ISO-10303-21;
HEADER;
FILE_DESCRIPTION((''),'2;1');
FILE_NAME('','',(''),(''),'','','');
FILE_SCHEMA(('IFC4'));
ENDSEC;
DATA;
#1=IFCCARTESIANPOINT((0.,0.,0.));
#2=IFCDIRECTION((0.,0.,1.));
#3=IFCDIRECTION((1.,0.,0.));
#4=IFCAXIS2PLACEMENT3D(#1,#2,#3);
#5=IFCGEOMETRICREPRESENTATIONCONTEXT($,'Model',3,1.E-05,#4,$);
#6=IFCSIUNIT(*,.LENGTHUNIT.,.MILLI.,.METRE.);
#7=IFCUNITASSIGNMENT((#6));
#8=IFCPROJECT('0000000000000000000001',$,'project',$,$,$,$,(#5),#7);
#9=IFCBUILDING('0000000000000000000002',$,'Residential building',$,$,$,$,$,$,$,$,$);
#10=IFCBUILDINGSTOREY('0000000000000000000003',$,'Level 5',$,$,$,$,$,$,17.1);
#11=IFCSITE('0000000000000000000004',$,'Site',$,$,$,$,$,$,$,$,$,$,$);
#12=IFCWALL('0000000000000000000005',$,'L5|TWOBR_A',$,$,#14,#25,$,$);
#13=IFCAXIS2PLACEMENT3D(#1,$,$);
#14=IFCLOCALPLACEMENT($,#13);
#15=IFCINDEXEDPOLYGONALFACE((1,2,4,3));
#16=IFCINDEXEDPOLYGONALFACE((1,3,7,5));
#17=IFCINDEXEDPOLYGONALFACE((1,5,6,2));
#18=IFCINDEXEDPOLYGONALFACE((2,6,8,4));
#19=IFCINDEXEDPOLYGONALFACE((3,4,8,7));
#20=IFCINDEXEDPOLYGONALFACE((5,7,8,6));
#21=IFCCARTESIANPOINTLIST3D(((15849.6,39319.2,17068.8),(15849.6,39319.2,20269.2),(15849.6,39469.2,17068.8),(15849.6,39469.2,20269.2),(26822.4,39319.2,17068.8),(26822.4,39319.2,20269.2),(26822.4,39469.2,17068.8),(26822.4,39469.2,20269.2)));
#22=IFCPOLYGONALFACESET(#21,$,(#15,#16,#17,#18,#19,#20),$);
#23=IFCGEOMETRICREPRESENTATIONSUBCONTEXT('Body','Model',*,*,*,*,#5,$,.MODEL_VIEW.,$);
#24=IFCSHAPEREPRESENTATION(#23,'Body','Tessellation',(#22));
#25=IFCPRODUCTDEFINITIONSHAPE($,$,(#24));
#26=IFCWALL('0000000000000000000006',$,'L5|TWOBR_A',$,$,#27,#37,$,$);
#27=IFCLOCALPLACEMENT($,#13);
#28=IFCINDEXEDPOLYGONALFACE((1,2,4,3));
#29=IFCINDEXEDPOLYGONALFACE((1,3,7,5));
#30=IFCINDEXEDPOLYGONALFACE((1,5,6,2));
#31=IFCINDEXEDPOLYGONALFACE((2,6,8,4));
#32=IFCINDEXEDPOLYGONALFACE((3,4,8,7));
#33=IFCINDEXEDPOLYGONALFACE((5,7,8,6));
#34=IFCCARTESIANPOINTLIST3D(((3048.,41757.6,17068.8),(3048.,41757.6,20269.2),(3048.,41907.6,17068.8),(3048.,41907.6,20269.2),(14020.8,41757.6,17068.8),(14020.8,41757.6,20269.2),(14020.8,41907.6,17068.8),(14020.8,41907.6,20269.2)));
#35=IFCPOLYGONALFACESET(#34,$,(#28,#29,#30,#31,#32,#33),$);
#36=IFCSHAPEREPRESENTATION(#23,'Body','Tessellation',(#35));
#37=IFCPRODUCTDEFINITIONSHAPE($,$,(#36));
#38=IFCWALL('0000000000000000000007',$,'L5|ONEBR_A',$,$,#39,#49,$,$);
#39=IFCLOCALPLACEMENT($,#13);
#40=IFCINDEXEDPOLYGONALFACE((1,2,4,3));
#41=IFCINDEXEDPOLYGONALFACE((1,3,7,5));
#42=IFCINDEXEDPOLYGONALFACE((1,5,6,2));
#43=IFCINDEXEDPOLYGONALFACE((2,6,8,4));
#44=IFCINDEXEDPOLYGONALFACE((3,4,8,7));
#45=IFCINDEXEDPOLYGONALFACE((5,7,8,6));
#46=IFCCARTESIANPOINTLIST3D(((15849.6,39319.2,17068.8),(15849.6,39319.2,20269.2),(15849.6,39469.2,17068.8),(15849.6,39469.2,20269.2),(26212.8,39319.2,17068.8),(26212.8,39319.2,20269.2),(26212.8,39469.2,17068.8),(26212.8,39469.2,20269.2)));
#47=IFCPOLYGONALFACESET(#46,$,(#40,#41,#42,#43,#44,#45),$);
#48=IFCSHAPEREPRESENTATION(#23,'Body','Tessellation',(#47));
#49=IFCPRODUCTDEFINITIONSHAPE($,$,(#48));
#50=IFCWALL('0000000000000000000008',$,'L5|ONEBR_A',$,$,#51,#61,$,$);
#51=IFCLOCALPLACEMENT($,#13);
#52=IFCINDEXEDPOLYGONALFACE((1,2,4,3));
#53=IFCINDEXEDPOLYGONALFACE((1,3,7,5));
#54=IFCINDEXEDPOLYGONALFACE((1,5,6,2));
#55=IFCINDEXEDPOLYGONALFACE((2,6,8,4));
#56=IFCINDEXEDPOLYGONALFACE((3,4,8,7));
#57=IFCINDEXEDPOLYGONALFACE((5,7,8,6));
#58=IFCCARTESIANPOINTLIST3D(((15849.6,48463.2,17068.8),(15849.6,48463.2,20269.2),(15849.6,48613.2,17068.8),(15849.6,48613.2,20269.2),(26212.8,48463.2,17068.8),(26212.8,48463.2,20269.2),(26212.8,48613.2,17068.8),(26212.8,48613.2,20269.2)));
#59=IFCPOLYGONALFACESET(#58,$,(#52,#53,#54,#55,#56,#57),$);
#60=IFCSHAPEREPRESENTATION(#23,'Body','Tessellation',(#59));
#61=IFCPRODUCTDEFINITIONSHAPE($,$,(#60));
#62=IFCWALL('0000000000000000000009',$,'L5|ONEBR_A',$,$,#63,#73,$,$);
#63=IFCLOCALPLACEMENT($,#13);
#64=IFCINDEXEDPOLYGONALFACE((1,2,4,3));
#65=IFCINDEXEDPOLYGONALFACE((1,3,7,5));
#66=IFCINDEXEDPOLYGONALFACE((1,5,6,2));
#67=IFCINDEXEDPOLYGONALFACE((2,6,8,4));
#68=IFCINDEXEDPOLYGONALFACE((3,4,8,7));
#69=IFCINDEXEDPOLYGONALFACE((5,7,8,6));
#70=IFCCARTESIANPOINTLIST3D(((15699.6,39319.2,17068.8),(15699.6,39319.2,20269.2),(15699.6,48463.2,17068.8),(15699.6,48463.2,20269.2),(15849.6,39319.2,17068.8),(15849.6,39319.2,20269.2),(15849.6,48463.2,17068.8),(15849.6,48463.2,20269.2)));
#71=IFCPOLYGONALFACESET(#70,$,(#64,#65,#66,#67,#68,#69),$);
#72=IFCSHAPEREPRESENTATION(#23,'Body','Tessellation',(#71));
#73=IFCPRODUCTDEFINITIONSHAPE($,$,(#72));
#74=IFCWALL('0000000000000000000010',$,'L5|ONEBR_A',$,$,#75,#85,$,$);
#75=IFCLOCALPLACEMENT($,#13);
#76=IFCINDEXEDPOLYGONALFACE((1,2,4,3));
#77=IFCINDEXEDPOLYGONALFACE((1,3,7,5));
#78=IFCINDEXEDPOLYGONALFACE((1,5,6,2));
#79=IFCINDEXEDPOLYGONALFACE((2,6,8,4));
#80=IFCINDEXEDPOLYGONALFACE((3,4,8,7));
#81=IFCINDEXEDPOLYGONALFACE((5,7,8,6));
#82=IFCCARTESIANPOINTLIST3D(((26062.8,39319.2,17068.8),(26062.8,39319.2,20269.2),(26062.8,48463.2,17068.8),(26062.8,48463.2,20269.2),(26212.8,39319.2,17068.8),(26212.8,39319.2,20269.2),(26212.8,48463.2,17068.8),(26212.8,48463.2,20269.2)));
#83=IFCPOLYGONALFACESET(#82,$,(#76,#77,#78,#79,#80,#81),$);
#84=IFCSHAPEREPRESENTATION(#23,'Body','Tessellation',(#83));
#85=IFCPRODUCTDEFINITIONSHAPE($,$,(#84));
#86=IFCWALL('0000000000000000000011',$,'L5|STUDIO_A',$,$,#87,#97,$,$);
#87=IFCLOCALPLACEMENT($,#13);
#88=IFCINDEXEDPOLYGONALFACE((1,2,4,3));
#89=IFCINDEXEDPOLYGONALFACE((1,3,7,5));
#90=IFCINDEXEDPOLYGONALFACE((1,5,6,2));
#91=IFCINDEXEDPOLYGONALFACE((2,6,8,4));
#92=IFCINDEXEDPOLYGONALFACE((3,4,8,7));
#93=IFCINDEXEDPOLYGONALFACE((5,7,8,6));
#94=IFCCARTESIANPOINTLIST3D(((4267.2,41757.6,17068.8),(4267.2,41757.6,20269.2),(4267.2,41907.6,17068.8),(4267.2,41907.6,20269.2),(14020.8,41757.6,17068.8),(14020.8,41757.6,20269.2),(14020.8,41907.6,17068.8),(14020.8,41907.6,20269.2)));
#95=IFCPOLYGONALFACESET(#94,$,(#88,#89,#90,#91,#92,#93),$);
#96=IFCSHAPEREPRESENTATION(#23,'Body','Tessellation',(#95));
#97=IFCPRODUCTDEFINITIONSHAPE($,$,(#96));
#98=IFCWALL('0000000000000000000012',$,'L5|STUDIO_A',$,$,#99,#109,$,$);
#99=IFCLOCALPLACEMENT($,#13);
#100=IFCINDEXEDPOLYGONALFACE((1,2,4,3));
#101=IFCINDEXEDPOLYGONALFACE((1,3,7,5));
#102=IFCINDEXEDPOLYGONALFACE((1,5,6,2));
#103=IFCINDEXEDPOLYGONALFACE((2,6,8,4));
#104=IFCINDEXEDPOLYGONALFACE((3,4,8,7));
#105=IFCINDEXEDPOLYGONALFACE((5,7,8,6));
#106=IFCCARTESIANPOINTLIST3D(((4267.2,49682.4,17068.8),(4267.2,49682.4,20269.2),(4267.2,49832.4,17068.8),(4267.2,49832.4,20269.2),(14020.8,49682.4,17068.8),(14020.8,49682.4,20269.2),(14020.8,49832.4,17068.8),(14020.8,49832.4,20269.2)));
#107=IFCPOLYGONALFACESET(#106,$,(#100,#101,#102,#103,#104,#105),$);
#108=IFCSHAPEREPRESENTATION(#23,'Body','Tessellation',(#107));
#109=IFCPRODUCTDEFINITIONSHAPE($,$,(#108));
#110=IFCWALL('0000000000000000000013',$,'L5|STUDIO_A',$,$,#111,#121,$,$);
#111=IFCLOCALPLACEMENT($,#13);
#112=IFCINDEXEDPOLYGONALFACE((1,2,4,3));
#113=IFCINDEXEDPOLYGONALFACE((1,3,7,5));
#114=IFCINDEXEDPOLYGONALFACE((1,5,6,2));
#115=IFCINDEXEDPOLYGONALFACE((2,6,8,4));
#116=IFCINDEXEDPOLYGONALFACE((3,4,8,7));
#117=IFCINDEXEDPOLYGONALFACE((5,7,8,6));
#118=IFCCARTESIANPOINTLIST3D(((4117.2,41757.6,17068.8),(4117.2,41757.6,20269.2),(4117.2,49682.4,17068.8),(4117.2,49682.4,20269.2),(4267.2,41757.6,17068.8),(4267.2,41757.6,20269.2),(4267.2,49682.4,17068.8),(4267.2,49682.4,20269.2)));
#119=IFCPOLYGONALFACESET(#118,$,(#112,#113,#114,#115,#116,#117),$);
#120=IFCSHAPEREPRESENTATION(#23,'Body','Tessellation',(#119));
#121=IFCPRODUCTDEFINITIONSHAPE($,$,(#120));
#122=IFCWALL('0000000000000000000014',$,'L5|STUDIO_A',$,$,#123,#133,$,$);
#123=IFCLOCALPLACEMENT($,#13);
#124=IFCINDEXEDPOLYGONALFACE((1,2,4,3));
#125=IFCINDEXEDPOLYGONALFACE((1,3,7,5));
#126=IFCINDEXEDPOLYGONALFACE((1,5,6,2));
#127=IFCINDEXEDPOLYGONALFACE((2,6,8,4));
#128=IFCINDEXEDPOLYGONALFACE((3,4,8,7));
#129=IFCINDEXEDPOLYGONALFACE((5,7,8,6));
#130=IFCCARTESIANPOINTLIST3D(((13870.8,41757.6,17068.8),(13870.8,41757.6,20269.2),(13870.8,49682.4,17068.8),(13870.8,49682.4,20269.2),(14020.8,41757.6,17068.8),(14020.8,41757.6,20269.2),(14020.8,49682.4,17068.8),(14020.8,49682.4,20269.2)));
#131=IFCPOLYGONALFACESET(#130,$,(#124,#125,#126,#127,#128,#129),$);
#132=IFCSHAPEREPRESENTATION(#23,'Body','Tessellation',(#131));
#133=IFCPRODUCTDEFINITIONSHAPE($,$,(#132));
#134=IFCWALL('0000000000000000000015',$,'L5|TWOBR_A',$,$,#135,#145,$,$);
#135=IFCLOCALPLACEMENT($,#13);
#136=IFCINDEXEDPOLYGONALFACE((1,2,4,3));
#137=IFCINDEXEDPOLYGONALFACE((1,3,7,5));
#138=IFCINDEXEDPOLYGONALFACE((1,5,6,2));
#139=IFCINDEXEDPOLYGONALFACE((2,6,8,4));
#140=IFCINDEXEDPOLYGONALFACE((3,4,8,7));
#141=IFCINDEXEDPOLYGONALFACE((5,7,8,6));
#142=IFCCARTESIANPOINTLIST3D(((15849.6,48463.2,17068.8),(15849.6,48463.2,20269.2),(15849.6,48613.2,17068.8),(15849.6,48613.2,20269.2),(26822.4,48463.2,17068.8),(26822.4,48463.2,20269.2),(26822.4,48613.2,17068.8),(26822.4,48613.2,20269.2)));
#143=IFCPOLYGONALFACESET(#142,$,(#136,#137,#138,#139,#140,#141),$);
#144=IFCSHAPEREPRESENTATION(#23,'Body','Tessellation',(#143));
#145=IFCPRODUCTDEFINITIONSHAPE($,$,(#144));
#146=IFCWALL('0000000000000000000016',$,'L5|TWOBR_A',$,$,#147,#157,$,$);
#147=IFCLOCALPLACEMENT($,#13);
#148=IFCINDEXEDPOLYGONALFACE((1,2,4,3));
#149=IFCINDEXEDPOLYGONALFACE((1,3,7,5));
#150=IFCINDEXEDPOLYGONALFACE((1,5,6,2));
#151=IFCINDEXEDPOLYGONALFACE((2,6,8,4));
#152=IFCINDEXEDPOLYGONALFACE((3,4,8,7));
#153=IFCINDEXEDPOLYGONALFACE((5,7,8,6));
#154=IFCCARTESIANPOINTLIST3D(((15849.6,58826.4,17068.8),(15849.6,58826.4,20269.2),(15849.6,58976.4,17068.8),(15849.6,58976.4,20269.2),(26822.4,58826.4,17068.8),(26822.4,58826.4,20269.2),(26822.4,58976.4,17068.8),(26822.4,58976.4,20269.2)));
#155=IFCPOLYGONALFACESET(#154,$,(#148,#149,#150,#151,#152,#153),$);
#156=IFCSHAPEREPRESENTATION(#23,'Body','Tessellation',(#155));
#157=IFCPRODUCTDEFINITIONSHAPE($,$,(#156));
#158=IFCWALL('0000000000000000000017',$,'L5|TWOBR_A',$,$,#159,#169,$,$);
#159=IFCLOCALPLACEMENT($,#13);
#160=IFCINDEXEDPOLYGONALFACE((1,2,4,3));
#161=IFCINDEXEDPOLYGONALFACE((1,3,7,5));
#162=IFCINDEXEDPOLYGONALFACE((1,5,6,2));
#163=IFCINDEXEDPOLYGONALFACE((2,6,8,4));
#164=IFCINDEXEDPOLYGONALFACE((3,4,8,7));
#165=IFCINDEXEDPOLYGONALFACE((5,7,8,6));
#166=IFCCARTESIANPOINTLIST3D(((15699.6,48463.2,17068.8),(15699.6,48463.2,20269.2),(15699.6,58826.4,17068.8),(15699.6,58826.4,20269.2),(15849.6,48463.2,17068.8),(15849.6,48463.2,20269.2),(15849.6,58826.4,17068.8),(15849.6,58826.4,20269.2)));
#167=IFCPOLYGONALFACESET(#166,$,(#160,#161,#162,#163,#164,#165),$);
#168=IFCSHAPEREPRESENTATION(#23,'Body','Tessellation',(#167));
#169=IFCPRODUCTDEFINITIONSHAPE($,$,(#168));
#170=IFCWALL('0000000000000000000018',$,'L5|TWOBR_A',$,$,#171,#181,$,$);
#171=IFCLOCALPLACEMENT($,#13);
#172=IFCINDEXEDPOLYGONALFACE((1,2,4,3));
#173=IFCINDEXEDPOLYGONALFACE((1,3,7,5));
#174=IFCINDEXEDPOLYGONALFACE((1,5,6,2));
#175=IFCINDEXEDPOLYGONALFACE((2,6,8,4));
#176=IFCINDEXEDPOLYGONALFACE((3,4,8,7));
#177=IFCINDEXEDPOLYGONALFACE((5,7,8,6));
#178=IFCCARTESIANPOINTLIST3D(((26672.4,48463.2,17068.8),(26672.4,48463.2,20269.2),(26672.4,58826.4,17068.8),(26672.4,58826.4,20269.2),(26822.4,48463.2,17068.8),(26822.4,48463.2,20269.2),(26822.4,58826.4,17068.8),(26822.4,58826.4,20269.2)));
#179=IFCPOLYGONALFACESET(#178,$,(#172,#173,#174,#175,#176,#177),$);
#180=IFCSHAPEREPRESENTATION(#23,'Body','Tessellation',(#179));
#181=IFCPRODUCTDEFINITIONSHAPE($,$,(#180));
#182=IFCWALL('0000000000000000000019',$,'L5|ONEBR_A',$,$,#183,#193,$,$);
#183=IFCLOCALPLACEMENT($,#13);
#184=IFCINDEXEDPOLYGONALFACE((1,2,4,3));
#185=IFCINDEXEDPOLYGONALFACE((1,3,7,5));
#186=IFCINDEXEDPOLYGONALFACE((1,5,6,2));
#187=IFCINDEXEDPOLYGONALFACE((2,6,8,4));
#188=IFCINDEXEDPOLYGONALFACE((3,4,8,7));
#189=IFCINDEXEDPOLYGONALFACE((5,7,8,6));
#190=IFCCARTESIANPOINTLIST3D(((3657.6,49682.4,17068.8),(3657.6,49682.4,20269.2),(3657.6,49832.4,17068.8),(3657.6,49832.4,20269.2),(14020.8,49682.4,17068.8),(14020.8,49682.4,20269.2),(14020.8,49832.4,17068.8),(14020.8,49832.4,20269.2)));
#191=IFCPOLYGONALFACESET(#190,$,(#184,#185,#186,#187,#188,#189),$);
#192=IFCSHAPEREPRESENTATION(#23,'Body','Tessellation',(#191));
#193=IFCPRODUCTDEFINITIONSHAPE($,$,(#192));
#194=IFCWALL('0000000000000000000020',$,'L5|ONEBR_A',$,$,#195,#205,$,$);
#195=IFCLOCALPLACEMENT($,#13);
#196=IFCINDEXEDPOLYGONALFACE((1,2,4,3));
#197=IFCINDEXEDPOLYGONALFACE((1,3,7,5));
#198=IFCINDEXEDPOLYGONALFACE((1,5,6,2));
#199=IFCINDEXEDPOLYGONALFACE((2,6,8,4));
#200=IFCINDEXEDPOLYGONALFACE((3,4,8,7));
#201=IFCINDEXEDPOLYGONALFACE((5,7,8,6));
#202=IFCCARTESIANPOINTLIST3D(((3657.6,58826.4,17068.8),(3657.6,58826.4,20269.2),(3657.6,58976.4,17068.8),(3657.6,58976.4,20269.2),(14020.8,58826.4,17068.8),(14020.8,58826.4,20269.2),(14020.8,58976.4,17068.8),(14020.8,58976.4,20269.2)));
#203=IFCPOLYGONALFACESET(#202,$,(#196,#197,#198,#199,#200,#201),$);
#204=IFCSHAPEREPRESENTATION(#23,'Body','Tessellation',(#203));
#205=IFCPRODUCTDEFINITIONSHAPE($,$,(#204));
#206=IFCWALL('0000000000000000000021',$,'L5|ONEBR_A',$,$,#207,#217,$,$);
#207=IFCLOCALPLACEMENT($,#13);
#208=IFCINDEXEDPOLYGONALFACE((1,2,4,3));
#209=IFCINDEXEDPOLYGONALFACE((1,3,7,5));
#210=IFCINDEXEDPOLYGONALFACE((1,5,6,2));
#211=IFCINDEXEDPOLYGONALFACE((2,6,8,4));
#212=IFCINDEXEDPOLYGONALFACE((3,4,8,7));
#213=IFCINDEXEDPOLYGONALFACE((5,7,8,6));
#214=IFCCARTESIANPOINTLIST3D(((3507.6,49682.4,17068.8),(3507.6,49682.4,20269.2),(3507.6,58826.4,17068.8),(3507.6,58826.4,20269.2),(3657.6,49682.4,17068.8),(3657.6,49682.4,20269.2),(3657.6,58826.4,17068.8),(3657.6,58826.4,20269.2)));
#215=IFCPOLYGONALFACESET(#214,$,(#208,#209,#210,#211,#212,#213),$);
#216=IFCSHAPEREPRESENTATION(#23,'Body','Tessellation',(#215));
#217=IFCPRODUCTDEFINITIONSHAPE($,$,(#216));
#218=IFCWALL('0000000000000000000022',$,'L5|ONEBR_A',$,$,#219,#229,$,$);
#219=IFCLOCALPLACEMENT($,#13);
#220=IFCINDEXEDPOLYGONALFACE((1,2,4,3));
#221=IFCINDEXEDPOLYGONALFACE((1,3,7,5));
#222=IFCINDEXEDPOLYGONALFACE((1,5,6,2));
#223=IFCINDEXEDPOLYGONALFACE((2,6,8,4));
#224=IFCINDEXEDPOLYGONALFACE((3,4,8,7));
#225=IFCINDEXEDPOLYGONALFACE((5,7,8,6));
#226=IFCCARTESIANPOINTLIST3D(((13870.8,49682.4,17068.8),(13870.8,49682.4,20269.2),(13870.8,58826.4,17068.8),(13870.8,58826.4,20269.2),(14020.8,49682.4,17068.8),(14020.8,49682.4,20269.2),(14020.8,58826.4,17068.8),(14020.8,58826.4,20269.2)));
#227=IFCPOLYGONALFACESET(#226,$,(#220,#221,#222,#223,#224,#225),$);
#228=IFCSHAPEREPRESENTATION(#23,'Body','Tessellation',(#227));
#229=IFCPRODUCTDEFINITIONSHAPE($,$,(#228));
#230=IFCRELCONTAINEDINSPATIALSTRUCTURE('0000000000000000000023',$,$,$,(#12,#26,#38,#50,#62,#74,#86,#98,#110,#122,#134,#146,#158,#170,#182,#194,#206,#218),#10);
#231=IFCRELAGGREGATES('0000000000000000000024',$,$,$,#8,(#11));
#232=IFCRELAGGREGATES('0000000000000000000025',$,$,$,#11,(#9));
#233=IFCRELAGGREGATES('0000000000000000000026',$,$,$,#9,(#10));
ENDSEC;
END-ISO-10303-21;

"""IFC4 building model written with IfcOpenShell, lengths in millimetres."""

from ifc_helpers import new_model, si_unit, frame, origin_with_axes, place, context, subcontext, project, spatial, indexed_curve, outline, extrude, element, save


model = new_model("IFC4")

# Units and contexts
model_context = context("Model", 3, precision=1e-05, world=origin_with_axes())
body_context = subcontext(model_context, "Body", "Model", "MODEL_VIEW")
ifc_project = project(units=[si_unit("LENGTHUNIT", "METRE", prefix="MILLI")], contexts=[model_context])

# Site, building, storey
site = spatial("IfcSite", under=ifc_project, Name="Site")
building = spatial("IfcBuilding", under=site, Name="Residential building")
storey = spatial("IfcBuildingStorey", under=building, Name="Level 5", Elevation=17.1)

# Walls
for number, where, z_axis, x_axis, name in (
    (1, (15849.6, 39319.2, 17068.8), (0.0, 0.0, 1.0), (1.0, 0.0, 0.0), "L5|TWOBR_A"),
    (2, (3048.0, 41757.6, 17068.8), (0.0, 0.0, 1.0), (1.0, 0.0, 0.0), "L5|TWOBR_A"),
):
    element("IfcWall", number, at=place(None, frame(where, z_axis=z_axis, x_axis=x_axis)), inside=storey, Name=name, context=body_context, shape_type="SweptSolid", body=[
        extrude(outline(indexed_curve([(0.0, 0.0), (0.0, 150.0), (10972.8, 150.0), (10972.8, 0.0), (0.0, 0.0)], self_intersect=False)), origin_with_axes(), (0.0, 0.0, 1.0), 3200.4),
    ])
for number, where, z_axis, x_axis, name in (
    (3, (15849.6, 39319.2, 17068.8), (0.0, 0.0, 1.0), (1.0, 0.0, 0.0), "L5|ONEBR_A"),
    (4, (15849.6, 48463.2, 17068.8), (0.0, 0.0, 1.0), (1.0, 0.0, 0.0), "L5|ONEBR_A"),
):
    element("IfcWall", number, at=place(None, frame(where, z_axis=z_axis, x_axis=x_axis)), inside=storey, Name=name, context=body_context, shape_type="SweptSolid", body=[
        extrude(outline(indexed_curve([(0.0, 0.0), (0.0, 150.0), (10363.2, 150.0), (10363.2, 0.0), (0.0, 0.0)], self_intersect=False)), origin_with_axes(), (0.0, 0.0, 1.0), 3200.4),
    ])
for number, where, z_axis, x_axis, name in (
    (5, (15849.6, 39319.2, 17068.8), (0.0, 0.0, 1.0), (0.0, 1.0, 0.0), "L5|ONEBR_A"),
    (6, (26212.8, 39319.2, 17068.8), (0.0, 0.0, 1.0), (0.0, 1.0, 0.0), "L5|ONEBR_A"),
):
    element("IfcWall", number, at=place(None, frame(where, z_axis=z_axis, x_axis=x_axis)), inside=storey, Name=name, context=body_context, shape_type="SweptSolid", body=[
        extrude(outline(indexed_curve([(0.0, 0.0), (0.0, 150.0), (9144.0, 150.0), (9144.0, 0.0), (0.0, 0.0)], self_intersect=False)), origin_with_axes(), (0.0, 0.0, 1.0), 3200.4),
    ])
for number, where, z_axis, x_axis, name in (
    (7, (4267.2, 41757.6, 17068.8), (0.0, 0.0, 1.0), (1.0, 0.0, 0.0), "L5|STUDIO_A"),
    (8, (4267.2, 49682.4, 17068.8), (0.0, 0.0, 1.0), (1.0, 0.0, 0.0), "L5|STUDIO_A"),
):
    element("IfcWall", number, at=place(None, frame(where, z_axis=z_axis, x_axis=x_axis)), inside=storey, Name=name, context=body_context, shape_type="SweptSolid", body=[
        extrude(outline(indexed_curve([(0.0, 0.0), (0.0, 150.0), (9753.6, 150.0), (9753.6, 0.0), (0.0, 0.0)], self_intersect=False)), origin_with_axes(), (0.0, 0.0, 1.0), 3200.4),
    ])
for number, where, z_axis, x_axis, name in (
    (9, (4267.2, 41757.6, 17068.8), (0.0, 0.0, 1.0), (0.0, 1.0, 0.0), "L5|STUDIO_A"),
    (10, (14020.8, 41757.6, 17068.8), (0.0, 0.0, 1.0), (0.0, 1.0, 0.0), "L5|STUDIO_A"),
):
    element("IfcWall", number, at=place(None, frame(where, z_axis=z_axis, x_axis=x_axis)), inside=storey, Name=name, context=body_context, shape_type="SweptSolid", body=[
        extrude(outline(indexed_curve([(0.0, 0.0), (0.0, 150.0), (7924.8, 150.0), (7924.8, 0.0), (0.0, 0.0)], self_intersect=False)), origin_with_axes(), (0.0, 0.0, 1.0), 3200.4),
    ])
for number, where, z_axis, x_axis, name in (
    (11, (15849.6, 48463.2, 17068.8), (0.0, 0.0, 1.0), (1.0, 0.0, 0.0), "L5|TWOBR_A"),
    (12, (15849.6, 58826.4, 17068.8), (0.0, 0.0, 1.0), (1.0, 0.0, 0.0), "L5|TWOBR_A"),
):
    element("IfcWall", number, at=place(None, frame(where, z_axis=z_axis, x_axis=x_axis)), inside=storey, Name=name, context=body_context, shape_type="SweptSolid", body=[
        extrude(outline(indexed_curve([(0.0, 0.0), (0.0, 150.0), (10972.8, 150.0), (10972.8, 0.0), (0.0, 0.0)], self_intersect=False)), origin_with_axes(), (0.0, 0.0, 1.0), 3200.4),
    ])
for number, where, z_axis, x_axis, name in (
    (13, (15849.6, 48463.2, 17068.8), (0.0, 0.0, 1.0), (0.0, 1.0, 0.0), "L5|TWOBR_A"),
    (14, (26822.4, 48463.2, 17068.8), (0.0, 0.0, 1.0), (0.0, 1.0, 0.0), "L5|TWOBR_A"),
    (15, (3657.6, 49682.4, 17068.8), (0.0, 0.0, 1.0), (1.0, 0.0, 0.0), "L5|ONEBR_A"),
    (16, (3657.6, 58826.4, 17068.8), (0.0, 0.0, 1.0), (1.0, 0.0, 0.0), "L5|ONEBR_A"),
):
    element("IfcWall", number, at=place(None, frame(where, z_axis=z_axis, x_axis=x_axis)), inside=storey, Name=name, context=body_context, shape_type="SweptSolid", body=[
        extrude(outline(indexed_curve([(0.0, 0.0), (0.0, 150.0), (10363.2, 150.0), (10363.2, 0.0), (0.0, 0.0)], self_intersect=False)), origin_with_axes(), (0.0, 0.0, 1.0), 3200.4),
    ])
for number, where, z_axis, x_axis, name in (
    (17, (3657.6, 49682.4, 17068.8), (0.0, 0.0, 1.0), (0.0, 1.0, 0.0), "L5|ONEBR_A"),
    (18, (14020.8, 49682.4, 17068.8), (0.0, 0.0, 1.0), (0.0, 1.0, 0.0), "L5|ONEBR_A"),
):
    element("IfcWall", number, at=place(None, frame(where, z_axis=z_axis, x_axis=x_axis)), inside=storey, Name=name, context=body_context, shape_type="SweptSolid", body=[
        extrude(outline(indexed_curve([(0.0, 0.0), (0.0, 150.0), (9144.0, 150.0), (9144.0, 0.0), (0.0, 0.0)], self_intersect=False)), origin_with_axes(), (0.0, 0.0, 1.0), 3200.4),
    ])

save(model, "model.ifc")
